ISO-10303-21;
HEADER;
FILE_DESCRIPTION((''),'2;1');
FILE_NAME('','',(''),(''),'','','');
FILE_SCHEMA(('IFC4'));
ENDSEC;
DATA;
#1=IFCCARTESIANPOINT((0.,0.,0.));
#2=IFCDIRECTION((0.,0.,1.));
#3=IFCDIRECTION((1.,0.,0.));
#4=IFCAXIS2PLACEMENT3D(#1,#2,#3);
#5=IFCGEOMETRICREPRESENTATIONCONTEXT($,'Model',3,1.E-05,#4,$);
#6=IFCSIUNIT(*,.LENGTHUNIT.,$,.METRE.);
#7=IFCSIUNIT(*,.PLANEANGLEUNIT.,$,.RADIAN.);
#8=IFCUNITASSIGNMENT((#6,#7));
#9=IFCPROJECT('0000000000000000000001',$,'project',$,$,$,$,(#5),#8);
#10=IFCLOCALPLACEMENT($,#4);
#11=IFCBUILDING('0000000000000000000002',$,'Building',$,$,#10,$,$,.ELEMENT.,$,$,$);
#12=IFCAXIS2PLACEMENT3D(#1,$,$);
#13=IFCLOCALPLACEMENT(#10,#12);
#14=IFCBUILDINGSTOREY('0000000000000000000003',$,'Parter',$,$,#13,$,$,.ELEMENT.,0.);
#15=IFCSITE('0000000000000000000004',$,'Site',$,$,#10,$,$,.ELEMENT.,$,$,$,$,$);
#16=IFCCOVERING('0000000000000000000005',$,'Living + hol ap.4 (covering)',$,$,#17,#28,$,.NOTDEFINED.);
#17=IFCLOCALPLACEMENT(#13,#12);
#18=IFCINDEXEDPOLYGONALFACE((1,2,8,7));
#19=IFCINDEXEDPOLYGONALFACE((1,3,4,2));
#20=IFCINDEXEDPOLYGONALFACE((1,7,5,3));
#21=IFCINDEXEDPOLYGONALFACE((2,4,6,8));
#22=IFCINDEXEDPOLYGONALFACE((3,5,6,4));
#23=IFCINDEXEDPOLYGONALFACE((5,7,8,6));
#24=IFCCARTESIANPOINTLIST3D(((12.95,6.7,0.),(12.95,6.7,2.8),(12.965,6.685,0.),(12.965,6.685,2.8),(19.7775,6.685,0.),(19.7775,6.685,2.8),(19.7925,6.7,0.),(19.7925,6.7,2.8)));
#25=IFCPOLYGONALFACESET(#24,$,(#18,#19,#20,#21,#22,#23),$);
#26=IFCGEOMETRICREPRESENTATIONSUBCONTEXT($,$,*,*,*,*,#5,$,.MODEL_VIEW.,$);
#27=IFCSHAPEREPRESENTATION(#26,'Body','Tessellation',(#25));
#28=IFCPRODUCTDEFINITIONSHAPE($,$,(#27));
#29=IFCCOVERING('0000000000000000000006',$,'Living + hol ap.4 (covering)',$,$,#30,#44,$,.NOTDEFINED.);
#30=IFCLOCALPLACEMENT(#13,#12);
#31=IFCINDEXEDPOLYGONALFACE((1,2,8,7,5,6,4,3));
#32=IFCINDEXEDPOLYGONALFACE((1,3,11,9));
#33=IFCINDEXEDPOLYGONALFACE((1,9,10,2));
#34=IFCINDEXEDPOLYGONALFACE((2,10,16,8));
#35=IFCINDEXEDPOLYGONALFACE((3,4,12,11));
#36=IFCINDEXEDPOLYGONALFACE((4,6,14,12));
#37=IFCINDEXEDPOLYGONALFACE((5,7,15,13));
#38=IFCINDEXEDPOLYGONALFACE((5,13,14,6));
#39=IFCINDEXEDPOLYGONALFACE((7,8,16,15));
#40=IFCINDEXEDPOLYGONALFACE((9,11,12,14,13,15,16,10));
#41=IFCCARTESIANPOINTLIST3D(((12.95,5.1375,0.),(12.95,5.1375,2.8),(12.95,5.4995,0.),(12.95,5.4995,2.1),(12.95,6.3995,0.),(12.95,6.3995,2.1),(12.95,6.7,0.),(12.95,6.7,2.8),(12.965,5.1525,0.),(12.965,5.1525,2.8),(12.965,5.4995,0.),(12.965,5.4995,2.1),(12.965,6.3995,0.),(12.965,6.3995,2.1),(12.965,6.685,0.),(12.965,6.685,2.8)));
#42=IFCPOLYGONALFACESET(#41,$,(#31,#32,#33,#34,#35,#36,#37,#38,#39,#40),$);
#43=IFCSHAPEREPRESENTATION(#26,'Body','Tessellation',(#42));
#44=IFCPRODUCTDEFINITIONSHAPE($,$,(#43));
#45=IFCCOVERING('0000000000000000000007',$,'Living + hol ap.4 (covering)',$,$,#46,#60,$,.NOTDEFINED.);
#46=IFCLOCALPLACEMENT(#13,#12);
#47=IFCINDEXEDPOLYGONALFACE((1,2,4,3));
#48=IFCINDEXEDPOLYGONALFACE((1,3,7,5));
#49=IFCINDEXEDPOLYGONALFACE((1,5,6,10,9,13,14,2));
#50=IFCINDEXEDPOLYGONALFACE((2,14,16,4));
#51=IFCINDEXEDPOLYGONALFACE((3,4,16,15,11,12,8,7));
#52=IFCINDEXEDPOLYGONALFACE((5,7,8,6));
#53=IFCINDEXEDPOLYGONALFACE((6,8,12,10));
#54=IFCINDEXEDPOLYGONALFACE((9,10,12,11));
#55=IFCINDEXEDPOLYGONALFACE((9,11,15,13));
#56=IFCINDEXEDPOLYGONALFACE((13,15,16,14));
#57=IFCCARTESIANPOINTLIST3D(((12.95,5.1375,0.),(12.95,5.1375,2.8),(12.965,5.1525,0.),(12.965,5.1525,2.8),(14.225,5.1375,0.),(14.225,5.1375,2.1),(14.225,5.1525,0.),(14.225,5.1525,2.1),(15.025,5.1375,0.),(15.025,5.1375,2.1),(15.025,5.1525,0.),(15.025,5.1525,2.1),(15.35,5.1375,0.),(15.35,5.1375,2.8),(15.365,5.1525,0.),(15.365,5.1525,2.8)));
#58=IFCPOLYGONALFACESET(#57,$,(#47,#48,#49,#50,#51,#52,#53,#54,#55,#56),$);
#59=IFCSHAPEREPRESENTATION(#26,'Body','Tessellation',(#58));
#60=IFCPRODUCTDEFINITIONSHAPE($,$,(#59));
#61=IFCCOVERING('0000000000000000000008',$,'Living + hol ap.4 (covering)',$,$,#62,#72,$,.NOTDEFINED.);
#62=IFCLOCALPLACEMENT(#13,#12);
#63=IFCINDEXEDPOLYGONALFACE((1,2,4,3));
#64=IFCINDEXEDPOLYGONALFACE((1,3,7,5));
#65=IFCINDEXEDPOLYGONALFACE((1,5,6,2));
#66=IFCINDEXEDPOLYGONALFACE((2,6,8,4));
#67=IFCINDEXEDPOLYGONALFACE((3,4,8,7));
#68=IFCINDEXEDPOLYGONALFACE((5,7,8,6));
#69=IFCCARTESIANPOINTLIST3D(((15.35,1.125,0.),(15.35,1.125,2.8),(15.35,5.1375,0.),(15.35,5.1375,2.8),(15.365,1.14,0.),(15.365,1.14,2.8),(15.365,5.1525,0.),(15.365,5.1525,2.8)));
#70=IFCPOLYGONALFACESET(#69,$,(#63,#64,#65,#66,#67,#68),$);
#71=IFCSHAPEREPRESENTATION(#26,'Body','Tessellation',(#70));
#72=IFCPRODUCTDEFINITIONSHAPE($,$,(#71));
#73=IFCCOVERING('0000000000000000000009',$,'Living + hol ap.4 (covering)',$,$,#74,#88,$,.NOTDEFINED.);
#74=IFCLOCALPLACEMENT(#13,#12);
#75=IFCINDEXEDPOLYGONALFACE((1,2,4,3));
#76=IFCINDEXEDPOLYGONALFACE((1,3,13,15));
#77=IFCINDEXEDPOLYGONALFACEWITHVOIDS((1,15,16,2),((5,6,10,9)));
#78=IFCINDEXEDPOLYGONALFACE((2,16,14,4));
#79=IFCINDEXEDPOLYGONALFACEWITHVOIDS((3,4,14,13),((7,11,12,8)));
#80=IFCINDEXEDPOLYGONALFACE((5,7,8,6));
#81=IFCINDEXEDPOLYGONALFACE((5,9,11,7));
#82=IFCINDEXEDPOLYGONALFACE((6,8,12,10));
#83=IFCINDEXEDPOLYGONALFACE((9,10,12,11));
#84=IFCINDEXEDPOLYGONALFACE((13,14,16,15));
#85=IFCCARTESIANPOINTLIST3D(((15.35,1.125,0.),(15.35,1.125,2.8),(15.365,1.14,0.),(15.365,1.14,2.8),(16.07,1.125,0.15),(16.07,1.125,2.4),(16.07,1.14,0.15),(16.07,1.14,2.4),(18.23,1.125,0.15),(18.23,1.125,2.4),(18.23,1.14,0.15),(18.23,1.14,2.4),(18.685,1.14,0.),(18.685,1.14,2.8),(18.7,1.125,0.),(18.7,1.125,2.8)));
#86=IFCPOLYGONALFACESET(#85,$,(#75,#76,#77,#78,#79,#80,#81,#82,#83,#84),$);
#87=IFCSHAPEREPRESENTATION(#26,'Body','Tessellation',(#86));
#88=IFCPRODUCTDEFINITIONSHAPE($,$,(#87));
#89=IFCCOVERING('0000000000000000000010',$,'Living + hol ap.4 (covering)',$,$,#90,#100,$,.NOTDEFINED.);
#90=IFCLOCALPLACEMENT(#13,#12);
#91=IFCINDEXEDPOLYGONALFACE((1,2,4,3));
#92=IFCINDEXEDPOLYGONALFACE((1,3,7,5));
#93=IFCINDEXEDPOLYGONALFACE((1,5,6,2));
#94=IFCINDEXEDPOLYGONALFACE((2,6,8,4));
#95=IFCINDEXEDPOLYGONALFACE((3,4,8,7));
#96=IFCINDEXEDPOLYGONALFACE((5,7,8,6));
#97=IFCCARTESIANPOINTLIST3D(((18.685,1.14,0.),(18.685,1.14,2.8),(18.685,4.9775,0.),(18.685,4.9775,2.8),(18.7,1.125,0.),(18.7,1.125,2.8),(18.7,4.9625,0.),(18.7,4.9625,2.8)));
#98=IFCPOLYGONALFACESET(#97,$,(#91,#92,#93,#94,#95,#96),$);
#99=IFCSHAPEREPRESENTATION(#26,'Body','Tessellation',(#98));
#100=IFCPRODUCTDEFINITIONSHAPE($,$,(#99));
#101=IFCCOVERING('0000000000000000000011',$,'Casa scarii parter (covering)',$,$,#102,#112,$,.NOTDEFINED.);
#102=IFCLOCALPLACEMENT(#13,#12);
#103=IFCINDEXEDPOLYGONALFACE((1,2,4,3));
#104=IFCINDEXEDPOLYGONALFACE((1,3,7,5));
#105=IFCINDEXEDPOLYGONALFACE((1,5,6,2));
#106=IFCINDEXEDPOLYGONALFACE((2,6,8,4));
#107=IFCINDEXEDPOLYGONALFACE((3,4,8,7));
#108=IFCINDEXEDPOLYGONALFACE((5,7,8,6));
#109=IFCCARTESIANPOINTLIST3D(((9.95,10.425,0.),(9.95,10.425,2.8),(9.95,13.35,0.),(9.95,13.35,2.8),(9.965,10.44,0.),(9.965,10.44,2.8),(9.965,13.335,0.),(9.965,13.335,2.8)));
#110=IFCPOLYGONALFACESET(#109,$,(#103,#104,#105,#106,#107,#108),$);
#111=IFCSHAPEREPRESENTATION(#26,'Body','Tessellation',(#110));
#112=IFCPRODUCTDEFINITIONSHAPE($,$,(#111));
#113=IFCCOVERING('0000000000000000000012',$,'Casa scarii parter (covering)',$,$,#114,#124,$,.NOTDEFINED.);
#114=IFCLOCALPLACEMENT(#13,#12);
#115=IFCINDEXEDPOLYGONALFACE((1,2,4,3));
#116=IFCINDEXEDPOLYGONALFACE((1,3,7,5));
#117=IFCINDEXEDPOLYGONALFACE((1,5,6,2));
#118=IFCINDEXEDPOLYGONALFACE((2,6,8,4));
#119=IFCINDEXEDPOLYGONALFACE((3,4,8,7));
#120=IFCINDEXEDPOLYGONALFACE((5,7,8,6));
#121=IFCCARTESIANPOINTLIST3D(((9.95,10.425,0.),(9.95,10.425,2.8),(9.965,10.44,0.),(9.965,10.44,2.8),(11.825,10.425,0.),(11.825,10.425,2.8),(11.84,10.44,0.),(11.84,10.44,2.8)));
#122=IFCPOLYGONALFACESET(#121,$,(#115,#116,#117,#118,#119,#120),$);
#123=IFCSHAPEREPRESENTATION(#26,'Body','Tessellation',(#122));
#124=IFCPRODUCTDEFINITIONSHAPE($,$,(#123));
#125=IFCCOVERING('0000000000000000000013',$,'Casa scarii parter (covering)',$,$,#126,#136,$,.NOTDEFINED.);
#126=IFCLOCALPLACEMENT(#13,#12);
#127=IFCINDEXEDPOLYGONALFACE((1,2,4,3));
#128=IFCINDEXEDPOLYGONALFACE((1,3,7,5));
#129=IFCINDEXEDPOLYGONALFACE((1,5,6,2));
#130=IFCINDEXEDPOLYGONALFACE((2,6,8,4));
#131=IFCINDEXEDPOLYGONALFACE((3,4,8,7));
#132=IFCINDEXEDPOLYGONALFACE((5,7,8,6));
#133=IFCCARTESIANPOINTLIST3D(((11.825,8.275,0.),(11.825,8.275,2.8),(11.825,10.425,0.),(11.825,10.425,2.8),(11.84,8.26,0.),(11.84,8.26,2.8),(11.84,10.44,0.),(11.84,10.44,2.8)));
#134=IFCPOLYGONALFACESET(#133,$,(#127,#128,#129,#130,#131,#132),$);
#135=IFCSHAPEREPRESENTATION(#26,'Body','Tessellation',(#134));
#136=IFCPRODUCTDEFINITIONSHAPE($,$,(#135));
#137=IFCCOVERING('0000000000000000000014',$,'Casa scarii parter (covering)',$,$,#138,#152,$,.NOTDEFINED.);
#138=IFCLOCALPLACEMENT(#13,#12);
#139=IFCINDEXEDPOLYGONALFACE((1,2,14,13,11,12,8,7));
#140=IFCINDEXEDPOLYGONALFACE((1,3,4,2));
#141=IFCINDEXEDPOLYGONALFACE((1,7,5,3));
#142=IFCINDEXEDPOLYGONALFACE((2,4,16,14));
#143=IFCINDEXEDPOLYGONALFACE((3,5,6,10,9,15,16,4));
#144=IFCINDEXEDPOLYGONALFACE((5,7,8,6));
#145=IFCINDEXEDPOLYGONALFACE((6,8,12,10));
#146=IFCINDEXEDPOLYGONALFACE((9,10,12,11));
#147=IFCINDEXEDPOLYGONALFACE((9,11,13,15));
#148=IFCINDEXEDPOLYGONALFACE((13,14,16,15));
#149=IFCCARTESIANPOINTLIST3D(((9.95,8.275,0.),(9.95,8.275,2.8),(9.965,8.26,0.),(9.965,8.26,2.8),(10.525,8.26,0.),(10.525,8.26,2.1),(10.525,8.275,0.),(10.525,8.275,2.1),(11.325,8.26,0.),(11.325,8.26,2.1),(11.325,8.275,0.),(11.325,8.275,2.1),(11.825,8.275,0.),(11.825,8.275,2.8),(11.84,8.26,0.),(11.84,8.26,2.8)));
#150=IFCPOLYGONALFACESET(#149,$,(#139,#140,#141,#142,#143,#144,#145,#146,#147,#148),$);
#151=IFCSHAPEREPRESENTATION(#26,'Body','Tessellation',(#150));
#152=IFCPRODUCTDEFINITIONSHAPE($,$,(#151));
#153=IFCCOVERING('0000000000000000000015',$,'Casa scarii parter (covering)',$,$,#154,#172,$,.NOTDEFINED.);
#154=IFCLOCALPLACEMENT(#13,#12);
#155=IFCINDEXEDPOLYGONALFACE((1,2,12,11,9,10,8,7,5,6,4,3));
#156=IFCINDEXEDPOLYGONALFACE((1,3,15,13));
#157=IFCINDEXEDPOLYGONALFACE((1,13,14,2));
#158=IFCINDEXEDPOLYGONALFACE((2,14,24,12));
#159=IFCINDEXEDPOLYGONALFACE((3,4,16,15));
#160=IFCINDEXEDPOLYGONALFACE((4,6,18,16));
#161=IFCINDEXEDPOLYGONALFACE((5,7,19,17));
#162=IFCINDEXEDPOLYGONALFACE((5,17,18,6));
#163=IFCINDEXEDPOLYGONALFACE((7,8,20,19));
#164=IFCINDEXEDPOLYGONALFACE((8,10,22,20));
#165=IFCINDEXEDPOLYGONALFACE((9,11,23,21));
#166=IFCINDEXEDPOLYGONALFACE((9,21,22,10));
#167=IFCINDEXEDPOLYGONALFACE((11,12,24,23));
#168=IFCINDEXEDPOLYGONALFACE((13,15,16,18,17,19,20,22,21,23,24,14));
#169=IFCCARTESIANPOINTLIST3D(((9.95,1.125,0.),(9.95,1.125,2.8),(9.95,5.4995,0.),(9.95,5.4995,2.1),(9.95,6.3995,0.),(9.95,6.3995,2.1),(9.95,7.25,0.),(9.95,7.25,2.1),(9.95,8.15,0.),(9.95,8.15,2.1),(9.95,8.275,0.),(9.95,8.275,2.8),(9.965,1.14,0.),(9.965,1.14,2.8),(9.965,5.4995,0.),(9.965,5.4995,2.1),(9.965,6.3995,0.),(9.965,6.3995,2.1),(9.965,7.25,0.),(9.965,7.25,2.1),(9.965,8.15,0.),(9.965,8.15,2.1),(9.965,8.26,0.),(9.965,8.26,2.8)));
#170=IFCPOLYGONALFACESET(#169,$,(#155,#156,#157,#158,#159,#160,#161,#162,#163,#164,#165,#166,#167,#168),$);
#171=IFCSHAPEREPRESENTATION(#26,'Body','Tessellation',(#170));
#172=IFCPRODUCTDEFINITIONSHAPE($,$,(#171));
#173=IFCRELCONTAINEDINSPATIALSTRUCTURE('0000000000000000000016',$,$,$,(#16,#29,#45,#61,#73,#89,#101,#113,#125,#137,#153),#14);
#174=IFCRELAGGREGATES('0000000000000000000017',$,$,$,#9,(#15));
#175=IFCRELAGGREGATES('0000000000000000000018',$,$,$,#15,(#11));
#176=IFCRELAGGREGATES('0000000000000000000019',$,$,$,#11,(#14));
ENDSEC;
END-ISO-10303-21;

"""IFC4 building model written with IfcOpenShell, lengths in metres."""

from ifc_helpers import new_model, si_unit, frame, origin, origin_with_axes, origin_2d, place, context, subcontext, project, spatial, polyline, rectangle, outline, extrude, element, save


model = new_model("IFC4")

# Units and contexts
model_context = context("Model", 3, precision=1e-05, world=origin_with_axes())
sub_context = subcontext(model_context, None, None, "MODEL_VIEW")
ifc_project = project(units=[si_unit("LENGTHUNIT", "METRE"), si_unit("PLANEANGLEUNIT", "RADIAN")], contexts=[model_context])

# Site, building, storey
placement = place(None, origin_with_axes())
site = spatial("IfcSite", under=ifc_project, at=placement, Name="Site", CompositionType="ELEMENT")
building = spatial("IfcBuilding", under=site, at=placement, Name="Building", CompositionType="ELEMENT")
storey_placement = place(placement, origin())
storey = spatial("IfcBuildingStorey", under=building, at=storey_placement, Name="Parter", CompositionType="ELEMENT", Elevation=0.0)

# Covering
covering_1_placement = place(storey_placement, origin_with_axes())
element("IfcCovering", 1, at=covering_1_placement, inside=storey, Name="Living + hol ap.4 (covering)", PredefinedType="NOTDEFINED", context=sub_context, shape_type="SweptSolid", body=[
    extrude(outline(polyline([(19.7925, 6.7), (12.95, 6.7), (12.965, 6.685), (19.7775, 6.685), (19.7925, 6.7)])), origin(), (0.0, 0.0, 1.0), 2.8),
])

# Coverings, openings
covering_2_placement = place(storey_placement, origin_with_axes())
covering_2 = element("IfcCovering", 2, at=covering_2_placement, inside=storey, Name="Living + hol ap.4 (covering)", PredefinedType="NOTDEFINED", context=sub_context, shape_type="SweptSolid", body=[
    extrude(outline(polyline([(12.95, 6.7), (12.95, 5.1375), (12.965, 5.1525), (12.965, 6.685), (12.95, 6.7)])), origin(), (0.0, 0.0, 1.0), 2.8),
])
opening_1_placement = place(covering_2_placement, frame((12.635, 5.9495, 0.0), z_axis=(1.0, 0.0, 0.0), x_axis=(0.0, 1.0, 0.0)))
element("IfcOpeningElement", 3, at=opening_1_placement, cuts=covering_2, PredefinedType="OPENING", context=sub_context, shape_type="SweptSolid", body=[
    extrude(rectangle(XDim=0.9, YDim=2.1, at=origin_2d()), frame((0.0, 1.05, 0.0)), (0.0, 0.0, 1.0), 0.38),
])
covering_3_placement = place(storey_placement, origin_with_axes())
covering_3 = element("IfcCovering", 4, at=covering_3_placement, inside=storey, Name="Living + hol ap.4 (covering)", PredefinedType="NOTDEFINED", context=sub_context, shape_type="SweptSolid", body=[
    extrude(outline(polyline([(12.95, 5.1375), (15.35, 5.1375), (15.365, 5.1525), (12.965, 5.1525), (12.95, 5.1375)])), origin(), (0.0, 0.0, 1.0), 2.8),
])
opening_2_placement = place(covering_3_placement, frame((14.625, 5.2025, 0.0), z_axis=(0.0, -1.0, 0.0), x_axis=(1.0, 0.0, 0.0)))
element("IfcOpeningElement", 5, at=opening_2_placement, cuts=covering_3, PredefinedType="OPENING", context=sub_context, shape_type="SweptSolid", body=[
    extrude(rectangle(XDim=0.8, YDim=2.1, at=origin_2d()), frame((0.0, 1.05, 0.0)), (0.0, 0.0, 1.0), 0.38),
])

# Covering
covering_4_placement = place(storey_placement, origin_with_axes())
element("IfcCovering", 6, at=covering_4_placement, inside=storey, Name="Living + hol ap.4 (covering)", PredefinedType="NOTDEFINED", context=sub_context, shape_type="SweptSolid", body=[
    extrude(outline(polyline([(15.35, 5.1375), (15.35, 1.125), (15.365, 1.14), (15.365, 5.1525), (15.35, 5.1375)])), origin(), (0.0, 0.0, 1.0), 2.8),
])

# Covering, opening
covering_5_placement = place(storey_placement, origin_with_axes())
covering_5 = element("IfcCovering", 7, at=covering_5_placement, inside=storey, Name="Living + hol ap.4 (covering)", PredefinedType="NOTDEFINED", context=sub_context, shape_type="SweptSolid", body=[
    extrude(outline(polyline([(15.35, 1.125), (18.7, 1.125), (18.685, 1.14), (15.365, 1.14), (15.35, 1.125)])), origin(), (0.0, 0.0, 1.0), 2.8),
])
opening_3_placement = place(covering_5_placement, frame((17.15, 1.19, 0.15), z_axis=(0.0, -1.0, 0.0), x_axis=(1.0, 0.0, 0.0)))
element("IfcOpeningElement", 8, at=opening_3_placement, cuts=covering_5, PredefinedType="OPENING", context=sub_context, shape_type="SweptSolid", body=[
    extrude(rectangle(XDim=2.16, YDim=2.25, at=origin_2d()), frame((0.0, 1.125, 0.0)), (0.0, 0.0, 1.0), 0.38),
])

# Coverings
covering_6_placement = place(storey_placement, origin_with_axes())
element("IfcCovering", 9, at=covering_6_placement, inside=storey, Name="Living + hol ap.4 (covering)", PredefinedType="NOTDEFINED", context=sub_context, shape_type="SweptSolid", body=[
    extrude(outline(polyline([(18.7, 1.125), (18.7, 4.9625), (18.685, 4.9775), (18.685, 1.14), (18.7, 1.125)])), origin(), (0.0, 0.0, 1.0), 2.8),
])
covering_7_placement = place(storey_placement, origin_with_axes())
element("IfcCovering", 10, at=covering_7_placement, inside=storey, Name="Casa scarii parter (covering)", PredefinedType="NOTDEFINED", context=sub_context, shape_type="SweptSolid", body=[
    extrude(outline(polyline([(9.95, 13.35), (9.95, 10.425), (9.965, 10.44), (9.965, 13.335), (9.95, 13.35)])), origin(), (0.0, 0.0, 1.0), 2.8),
])
covering_8_placement = place(storey_placement, origin_with_axes())
element("IfcCovering", 11, at=covering_8_placement, inside=storey, Name="Casa scarii parter (covering)", PredefinedType="NOTDEFINED", context=sub_context, shape_type="SweptSolid", body=[
    extrude(outline(polyline([(9.95, 10.425), (11.825, 10.425), (11.84, 10.44), (9.965, 10.44), (9.95, 10.425)])), origin(), (0.0, 0.0, 1.0), 2.8),
])
covering_9_placement = place(storey_placement, origin_with_axes())
element("IfcCovering", 12, at=covering_9_placement, inside=storey, Name="Casa scarii parter (covering)", PredefinedType="NOTDEFINED", context=sub_context, shape_type="SweptSolid", body=[
    extrude(outline(polyline([(11.825, 10.425), (11.825, 8.275), (11.84, 8.26), (11.84, 10.44), (11.825, 10.425)])), origin(), (0.0, 0.0, 1.0), 2.8),
])

# Covering, opening
covering_10_placement = place(storey_placement, origin_with_axes())
covering_10 = element("IfcCovering", 13, at=covering_10_placement, inside=storey, Name="Casa scarii parter (covering)", PredefinedType="NOTDEFINED", context=sub_context, shape_type="SweptSolid", body=[
    extrude(outline(polyline([(11.825, 8.275), (9.95, 8.275), (9.965, 8.26), (11.84, 8.26), (11.825, 8.275)])), origin(), (0.0, 0.0, 1.0), 2.8),
])
opening_4_placement = place(covering_10_placement, frame((10.925, 8.59, 0.0), z_axis=(0.0, -1.0, 0.0), x_axis=(1.0, 0.0, 0.0)))
element("IfcOpeningElement", 14, at=opening_4_placement, cuts=covering_10, PredefinedType="OPENING", context=sub_context, shape_type="SweptSolid", body=[
    extrude(rectangle(XDim=0.8, YDim=2.1, at=origin_2d()), frame((0.0, 1.05, 0.0)), (0.0, 0.0, 1.0), 0.38),
])

# Covering, openings
covering_11_placement = place(storey_placement, origin_with_axes())
covering_11 = element("IfcCovering", 15, at=covering_11_placement, inside=storey, Name="Casa scarii parter (covering)", PredefinedType="NOTDEFINED", context=sub_context, shape_type="SweptSolid", body=[
    extrude(outline(polyline([(9.95, 8.275), (9.95, 1.125), (9.965, 1.14), (9.965, 8.26), (9.95, 8.275)])), origin(), (0.0, 0.0, 1.0), 2.8),
])
opening_5_placement = place(covering_11_placement, frame((9.635, 5.9495, 0.0), z_axis=(1.0, 0.0, 0.0), x_axis=(0.0, 1.0, 0.0)))
element("IfcOpeningElement", 16, at=opening_5_placement, cuts=covering_11, PredefinedType="OPENING", context=sub_context, shape_type="SweptSolid", body=[
    extrude(rectangle(XDim=0.9, YDim=2.1, at=origin_2d()), frame((0.0, 1.05, 0.0)), (0.0, 0.0, 1.0), 0.38),
])
opening_6_placement = place(covering_11_placement, frame((9.635, 7.7, 0.0), z_axis=(1.0, 0.0, 0.0), x_axis=(0.0, 1.0, 0.0)))
element("IfcOpeningElement", 17, at=opening_6_placement, cuts=covering_11, PredefinedType="OPENING", context=sub_context, shape_type="SweptSolid", body=[
    extrude(rectangle(XDim=0.9, YDim=2.1, at=origin_2d()), frame((0.0, 1.05, 0.0)), (0.0, 0.0, 1.0), 0.38),
])

save(model, "model.ifc")
